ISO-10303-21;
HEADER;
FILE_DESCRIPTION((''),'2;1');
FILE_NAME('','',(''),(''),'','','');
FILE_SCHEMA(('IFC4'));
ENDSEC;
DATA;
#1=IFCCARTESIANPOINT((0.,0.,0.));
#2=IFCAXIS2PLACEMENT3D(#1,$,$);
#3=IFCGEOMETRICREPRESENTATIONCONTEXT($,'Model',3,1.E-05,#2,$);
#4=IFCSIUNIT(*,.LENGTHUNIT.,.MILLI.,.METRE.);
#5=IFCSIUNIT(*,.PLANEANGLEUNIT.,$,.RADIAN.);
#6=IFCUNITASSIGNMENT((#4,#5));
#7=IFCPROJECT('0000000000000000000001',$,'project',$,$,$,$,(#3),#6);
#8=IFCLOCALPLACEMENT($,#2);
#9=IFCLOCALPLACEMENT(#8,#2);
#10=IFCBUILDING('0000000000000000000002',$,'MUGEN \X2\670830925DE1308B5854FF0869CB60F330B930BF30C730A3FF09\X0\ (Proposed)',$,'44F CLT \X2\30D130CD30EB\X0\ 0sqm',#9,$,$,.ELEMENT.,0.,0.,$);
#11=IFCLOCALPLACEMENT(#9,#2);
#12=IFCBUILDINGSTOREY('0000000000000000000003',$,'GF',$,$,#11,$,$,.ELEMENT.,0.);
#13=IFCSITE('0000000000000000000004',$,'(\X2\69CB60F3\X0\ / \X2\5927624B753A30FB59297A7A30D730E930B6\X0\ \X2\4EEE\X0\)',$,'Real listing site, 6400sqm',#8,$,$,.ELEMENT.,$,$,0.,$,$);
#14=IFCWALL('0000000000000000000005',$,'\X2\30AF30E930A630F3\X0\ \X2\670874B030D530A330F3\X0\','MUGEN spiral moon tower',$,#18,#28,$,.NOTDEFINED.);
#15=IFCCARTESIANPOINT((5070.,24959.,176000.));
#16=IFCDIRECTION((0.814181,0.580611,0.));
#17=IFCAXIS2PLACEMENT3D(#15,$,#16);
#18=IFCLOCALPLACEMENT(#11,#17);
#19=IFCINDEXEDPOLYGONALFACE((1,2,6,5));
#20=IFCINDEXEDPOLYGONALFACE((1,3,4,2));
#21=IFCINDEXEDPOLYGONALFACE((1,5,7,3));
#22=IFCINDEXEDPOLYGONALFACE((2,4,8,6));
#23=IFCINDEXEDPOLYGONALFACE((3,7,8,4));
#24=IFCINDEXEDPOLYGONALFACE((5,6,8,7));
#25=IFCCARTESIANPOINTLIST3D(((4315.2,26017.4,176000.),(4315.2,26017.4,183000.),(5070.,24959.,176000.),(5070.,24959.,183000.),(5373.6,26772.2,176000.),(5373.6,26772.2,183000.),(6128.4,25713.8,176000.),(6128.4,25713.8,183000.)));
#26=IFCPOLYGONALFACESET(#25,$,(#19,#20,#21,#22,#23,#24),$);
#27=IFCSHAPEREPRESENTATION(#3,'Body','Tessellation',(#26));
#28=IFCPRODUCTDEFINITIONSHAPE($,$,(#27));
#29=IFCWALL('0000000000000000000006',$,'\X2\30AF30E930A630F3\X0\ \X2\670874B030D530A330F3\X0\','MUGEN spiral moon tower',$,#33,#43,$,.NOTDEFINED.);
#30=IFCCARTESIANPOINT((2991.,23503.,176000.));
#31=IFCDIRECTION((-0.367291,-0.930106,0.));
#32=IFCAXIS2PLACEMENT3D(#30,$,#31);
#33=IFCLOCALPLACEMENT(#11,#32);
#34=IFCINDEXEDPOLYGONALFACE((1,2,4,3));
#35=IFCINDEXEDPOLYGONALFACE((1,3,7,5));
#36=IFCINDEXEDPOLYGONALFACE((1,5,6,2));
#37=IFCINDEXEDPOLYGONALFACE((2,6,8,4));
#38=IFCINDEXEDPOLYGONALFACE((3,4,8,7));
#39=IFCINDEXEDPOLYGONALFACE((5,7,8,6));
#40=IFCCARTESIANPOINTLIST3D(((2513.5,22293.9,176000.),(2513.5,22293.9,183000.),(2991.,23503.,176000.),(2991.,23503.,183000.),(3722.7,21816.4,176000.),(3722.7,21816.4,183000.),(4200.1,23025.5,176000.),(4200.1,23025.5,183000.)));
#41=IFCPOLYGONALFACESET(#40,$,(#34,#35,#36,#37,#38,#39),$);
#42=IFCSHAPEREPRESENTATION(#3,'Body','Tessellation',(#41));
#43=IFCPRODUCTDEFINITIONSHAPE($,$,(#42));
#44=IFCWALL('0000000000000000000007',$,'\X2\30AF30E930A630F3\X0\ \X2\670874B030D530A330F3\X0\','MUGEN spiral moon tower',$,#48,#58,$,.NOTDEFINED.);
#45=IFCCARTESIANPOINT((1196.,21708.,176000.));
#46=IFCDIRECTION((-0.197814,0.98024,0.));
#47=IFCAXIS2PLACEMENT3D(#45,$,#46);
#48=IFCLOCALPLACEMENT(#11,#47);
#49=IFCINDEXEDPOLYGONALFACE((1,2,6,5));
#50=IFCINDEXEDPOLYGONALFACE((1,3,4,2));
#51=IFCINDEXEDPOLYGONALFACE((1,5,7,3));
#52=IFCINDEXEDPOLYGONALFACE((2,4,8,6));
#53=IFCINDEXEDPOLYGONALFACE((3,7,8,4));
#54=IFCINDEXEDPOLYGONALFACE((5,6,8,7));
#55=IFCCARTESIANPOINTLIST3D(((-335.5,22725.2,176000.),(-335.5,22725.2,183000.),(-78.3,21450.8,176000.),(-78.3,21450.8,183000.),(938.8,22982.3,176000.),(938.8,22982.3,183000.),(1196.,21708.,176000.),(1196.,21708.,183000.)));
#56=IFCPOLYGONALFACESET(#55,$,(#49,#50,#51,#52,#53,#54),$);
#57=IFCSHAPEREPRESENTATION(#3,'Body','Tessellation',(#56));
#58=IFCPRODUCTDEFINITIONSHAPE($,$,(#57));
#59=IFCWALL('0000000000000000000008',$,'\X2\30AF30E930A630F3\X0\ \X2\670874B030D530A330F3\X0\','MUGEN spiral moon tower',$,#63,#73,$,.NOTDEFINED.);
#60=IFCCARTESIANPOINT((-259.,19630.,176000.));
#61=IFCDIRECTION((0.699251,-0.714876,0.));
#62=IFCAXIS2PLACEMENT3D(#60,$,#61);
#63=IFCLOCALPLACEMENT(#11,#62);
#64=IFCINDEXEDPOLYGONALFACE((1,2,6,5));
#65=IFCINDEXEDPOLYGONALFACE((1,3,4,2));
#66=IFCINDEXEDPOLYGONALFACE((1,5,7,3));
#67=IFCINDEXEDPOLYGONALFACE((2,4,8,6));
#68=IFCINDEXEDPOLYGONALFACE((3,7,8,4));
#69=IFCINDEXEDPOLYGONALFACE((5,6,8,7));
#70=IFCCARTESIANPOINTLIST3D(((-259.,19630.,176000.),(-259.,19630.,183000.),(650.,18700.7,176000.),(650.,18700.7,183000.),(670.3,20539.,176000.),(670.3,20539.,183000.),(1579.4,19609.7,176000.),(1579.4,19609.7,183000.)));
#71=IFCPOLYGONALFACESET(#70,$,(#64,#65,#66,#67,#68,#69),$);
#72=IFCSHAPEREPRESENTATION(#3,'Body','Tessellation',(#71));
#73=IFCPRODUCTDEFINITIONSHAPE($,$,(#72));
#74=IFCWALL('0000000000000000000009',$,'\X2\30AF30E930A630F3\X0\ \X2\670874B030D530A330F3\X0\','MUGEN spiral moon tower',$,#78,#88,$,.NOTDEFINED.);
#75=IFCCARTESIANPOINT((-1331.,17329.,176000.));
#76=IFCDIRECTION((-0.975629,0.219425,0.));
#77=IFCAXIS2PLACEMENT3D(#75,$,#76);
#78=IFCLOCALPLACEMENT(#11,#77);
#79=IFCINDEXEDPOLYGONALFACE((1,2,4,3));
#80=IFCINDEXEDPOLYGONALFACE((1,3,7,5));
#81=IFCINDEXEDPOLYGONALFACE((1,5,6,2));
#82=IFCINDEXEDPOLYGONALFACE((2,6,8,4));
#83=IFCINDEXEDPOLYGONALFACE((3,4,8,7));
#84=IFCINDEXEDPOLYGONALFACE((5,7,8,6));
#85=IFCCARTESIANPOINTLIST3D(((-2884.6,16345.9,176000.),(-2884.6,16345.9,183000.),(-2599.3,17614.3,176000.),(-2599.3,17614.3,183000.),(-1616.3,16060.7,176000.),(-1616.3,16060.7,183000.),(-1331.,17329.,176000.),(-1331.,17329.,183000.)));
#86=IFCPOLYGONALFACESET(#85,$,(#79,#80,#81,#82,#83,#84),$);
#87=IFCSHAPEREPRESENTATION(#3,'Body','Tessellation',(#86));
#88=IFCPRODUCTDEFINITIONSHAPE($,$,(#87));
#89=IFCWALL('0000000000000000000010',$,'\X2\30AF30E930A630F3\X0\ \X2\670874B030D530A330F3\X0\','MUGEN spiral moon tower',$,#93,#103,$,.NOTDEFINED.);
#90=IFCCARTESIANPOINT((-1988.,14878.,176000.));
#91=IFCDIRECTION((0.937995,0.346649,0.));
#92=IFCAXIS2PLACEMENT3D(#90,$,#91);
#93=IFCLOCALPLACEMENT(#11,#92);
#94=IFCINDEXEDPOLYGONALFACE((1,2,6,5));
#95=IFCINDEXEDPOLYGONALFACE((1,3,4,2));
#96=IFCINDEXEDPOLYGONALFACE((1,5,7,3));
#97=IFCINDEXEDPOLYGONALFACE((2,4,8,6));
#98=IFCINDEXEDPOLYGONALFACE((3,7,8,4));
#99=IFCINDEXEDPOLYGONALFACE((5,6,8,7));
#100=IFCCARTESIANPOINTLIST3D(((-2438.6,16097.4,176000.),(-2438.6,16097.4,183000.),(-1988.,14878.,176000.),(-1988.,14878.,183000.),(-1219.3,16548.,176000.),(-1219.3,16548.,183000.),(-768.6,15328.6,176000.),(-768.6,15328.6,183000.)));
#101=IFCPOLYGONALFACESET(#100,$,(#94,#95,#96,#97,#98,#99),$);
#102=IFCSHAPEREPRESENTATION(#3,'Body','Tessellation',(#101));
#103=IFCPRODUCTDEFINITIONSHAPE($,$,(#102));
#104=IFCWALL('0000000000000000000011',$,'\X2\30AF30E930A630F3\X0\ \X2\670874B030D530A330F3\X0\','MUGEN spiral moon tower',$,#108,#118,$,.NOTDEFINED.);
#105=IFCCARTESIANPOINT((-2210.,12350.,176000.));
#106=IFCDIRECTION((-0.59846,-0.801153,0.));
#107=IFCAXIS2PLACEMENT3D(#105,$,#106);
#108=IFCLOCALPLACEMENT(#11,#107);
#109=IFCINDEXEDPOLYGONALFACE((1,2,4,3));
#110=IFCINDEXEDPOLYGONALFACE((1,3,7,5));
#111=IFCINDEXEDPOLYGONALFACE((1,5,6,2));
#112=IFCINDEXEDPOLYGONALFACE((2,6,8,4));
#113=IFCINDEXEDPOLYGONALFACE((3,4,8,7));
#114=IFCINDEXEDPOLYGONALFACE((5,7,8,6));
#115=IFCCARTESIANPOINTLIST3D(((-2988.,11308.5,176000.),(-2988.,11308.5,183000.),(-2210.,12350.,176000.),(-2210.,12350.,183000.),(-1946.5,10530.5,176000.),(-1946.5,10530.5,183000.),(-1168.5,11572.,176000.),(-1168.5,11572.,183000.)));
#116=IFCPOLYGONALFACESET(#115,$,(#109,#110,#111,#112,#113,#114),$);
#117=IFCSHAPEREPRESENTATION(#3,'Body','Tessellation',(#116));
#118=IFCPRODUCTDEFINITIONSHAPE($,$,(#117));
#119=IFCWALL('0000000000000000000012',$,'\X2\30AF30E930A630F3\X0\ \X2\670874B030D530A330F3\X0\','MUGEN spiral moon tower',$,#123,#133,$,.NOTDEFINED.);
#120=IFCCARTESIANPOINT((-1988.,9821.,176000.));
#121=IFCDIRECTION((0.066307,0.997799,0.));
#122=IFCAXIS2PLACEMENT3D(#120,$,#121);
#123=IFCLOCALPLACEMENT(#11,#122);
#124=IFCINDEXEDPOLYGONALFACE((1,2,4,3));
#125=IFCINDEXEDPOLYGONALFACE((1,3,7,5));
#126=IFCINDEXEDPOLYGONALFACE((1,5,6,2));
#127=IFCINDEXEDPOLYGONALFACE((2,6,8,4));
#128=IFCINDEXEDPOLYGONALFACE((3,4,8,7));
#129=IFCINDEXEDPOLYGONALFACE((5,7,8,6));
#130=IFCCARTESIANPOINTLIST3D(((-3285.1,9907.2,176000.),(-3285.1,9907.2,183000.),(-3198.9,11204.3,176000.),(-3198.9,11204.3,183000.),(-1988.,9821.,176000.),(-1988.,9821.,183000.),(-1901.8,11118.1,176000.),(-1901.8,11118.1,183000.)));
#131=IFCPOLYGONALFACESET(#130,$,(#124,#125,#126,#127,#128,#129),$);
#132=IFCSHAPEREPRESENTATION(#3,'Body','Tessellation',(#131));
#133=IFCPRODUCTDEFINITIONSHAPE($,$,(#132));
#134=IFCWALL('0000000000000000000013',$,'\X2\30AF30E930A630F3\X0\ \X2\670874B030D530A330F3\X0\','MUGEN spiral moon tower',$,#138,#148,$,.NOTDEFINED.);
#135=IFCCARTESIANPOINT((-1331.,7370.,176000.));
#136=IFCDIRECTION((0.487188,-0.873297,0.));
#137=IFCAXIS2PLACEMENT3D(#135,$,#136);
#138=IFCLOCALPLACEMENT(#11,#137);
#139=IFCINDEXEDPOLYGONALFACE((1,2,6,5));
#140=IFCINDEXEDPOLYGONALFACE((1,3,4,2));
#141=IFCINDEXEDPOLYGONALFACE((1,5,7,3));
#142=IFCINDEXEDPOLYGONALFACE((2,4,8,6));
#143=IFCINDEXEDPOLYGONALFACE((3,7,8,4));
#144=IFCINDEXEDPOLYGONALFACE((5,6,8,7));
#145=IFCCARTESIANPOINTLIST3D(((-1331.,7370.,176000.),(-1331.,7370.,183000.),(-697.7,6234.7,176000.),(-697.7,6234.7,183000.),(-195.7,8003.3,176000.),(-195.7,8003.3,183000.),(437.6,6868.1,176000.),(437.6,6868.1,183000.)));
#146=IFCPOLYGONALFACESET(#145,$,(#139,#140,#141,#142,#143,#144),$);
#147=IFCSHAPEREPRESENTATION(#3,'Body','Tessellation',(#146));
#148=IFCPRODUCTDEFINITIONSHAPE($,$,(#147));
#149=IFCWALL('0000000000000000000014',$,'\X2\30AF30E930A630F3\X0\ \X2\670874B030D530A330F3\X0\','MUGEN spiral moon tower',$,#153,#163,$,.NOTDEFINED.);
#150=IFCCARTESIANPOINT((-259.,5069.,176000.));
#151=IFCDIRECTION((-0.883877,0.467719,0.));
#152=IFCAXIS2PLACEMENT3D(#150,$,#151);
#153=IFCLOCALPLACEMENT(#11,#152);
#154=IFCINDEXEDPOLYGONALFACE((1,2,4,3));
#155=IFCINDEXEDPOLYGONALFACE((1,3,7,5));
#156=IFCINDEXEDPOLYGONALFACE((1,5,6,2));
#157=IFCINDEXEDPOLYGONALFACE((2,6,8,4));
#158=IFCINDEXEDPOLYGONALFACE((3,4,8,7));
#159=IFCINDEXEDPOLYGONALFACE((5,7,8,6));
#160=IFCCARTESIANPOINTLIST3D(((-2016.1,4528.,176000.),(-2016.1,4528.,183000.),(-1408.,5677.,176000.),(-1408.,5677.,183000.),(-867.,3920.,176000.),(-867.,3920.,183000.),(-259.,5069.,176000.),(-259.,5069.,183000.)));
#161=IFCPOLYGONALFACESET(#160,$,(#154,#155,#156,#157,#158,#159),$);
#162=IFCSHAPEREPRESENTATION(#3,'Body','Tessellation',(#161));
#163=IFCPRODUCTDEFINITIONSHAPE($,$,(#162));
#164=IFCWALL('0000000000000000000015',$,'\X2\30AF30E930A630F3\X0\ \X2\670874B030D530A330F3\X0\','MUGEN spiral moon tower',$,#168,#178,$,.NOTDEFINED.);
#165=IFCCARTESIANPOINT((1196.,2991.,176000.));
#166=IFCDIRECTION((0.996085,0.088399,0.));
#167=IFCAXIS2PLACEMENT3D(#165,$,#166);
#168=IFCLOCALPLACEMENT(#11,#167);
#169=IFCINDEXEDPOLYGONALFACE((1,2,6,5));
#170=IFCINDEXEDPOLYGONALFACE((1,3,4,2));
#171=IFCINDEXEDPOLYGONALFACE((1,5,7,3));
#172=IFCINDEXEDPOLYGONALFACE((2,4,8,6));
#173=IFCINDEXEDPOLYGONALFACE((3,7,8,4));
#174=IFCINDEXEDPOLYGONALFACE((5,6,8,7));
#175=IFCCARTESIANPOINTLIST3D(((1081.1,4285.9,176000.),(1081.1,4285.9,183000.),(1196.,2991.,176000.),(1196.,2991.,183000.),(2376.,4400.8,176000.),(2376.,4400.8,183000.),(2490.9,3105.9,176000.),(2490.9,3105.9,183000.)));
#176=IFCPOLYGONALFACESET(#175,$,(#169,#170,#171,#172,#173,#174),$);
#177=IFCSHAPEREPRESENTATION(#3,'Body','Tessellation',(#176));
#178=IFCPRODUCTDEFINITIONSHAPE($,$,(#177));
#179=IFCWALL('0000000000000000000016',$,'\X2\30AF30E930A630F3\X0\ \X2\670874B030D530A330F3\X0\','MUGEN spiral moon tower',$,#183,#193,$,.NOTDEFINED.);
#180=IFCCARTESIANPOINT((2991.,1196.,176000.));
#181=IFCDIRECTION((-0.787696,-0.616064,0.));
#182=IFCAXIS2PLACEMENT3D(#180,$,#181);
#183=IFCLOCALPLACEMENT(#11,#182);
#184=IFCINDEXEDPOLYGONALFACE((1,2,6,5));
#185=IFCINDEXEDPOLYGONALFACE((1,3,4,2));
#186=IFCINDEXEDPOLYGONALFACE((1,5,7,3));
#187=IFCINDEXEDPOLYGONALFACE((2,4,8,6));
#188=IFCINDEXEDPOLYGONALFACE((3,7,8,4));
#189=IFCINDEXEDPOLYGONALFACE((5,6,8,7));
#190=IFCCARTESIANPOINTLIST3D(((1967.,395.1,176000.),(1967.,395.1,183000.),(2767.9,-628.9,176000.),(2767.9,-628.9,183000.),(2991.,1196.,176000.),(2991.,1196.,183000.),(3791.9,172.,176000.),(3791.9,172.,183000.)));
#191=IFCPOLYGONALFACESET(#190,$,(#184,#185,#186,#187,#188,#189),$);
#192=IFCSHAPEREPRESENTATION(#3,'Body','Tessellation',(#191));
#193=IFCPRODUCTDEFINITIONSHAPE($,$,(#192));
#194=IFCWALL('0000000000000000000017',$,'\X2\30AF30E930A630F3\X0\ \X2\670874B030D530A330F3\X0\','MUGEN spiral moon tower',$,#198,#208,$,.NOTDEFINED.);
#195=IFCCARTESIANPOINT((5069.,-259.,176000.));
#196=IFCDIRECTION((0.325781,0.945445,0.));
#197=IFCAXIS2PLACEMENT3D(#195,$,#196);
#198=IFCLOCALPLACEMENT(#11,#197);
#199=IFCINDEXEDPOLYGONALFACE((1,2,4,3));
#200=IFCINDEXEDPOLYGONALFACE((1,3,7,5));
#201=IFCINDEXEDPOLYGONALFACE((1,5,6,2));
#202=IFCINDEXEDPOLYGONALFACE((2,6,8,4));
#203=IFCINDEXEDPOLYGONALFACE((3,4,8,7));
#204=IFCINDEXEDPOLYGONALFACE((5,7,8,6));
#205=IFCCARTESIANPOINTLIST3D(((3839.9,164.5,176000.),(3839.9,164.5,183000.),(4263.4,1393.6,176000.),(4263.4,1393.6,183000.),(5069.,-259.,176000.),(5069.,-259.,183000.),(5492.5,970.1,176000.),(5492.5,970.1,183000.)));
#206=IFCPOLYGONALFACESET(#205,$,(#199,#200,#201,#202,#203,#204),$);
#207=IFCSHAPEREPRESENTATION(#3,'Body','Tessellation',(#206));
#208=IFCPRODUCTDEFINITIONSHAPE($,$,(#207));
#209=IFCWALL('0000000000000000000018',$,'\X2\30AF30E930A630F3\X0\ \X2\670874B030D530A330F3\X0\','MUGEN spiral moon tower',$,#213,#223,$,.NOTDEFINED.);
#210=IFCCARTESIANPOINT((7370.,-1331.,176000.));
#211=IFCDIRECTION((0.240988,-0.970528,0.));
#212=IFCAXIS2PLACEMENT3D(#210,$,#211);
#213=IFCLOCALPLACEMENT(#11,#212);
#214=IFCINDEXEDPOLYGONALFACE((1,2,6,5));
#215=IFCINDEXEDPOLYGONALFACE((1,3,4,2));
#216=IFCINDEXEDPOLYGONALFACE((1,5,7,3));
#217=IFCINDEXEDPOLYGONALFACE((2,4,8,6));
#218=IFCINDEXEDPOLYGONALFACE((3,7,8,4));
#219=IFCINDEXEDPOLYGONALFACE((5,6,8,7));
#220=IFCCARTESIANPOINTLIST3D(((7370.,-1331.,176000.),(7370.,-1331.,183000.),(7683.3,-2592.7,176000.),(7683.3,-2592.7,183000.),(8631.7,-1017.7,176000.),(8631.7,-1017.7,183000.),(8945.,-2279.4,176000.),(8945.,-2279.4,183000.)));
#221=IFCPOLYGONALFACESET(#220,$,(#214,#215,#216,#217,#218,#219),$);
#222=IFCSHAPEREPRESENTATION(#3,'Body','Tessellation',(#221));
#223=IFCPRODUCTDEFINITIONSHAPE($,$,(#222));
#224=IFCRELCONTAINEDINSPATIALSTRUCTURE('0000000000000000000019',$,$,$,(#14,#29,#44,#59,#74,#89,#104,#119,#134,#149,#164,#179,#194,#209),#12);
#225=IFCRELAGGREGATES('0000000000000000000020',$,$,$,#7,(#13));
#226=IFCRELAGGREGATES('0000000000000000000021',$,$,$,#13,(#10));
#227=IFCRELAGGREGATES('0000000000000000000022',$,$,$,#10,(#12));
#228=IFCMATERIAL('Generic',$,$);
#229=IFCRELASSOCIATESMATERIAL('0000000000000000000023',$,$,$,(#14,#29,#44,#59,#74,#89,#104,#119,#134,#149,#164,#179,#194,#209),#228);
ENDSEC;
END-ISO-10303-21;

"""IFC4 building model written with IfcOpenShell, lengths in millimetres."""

from ifc_helpers import new_model, si_unit, frame, frame_2d, origin, place, context, project, spatial, rectangle, extrude, material, element, save


model = new_model("IFC4")

# Units and contexts
model_context = context("Model", 3, precision=1e-05, world=origin())
ifc_project = project(units=[si_unit("LENGTHUNIT", "METRE", prefix="MILLI"), si_unit("PLANEANGLEUNIT", "RADIAN")], contexts=[model_context])

# Site, building, storey
site_placement = place(None, origin())
site = spatial("IfcSite", under=ifc_project, at=site_placement, Name="(構想 / 大手町・天空プラザ 仮)", ObjectType="Real listing site, 6400sqm", CompositionType="ELEMENT", RefElevation=0.0)
building_placement = place(site_placement, origin())
building = spatial("IfcBuilding", under=site, at=building_placement, Name="MUGEN 月を巡る塔（構想スタディ） (Proposed)", ObjectType="44F CLT パネル 0sqm", CompositionType="ELEMENT", ElevationOfRefHeight=0.0, ElevationOfTerrain=0.0)
storey_placement = place(building_placement, origin())
storey = spatial("IfcBuildingStorey", under=building, at=storey_placement, Name="GF", CompositionType="ELEMENT", Elevation=0.0)

# Shared definitions
ifc_material = material(Name="Generic")

# Walls
wall_1_placement = place(storey_placement, frame((5070.0, 24959.0, 176000.0), x_axis=(0.814181, 0.580611, 0.0)))
element("IfcWall", 1, at=wall_1_placement, inside=storey, material=ifc_material, Name="クラウン 月環フィン", Description="MUGEN spiral moon tower", PredefinedType="NOTDEFINED", context=model_context, shape_type="SweptSolid", body=[
    extrude(rectangle(XDim=1300.0, YDim=1300.0, at=frame_2d((650.0, 650.0))), frame((5070.0, 24959.0, 176000.0), x_axis=(0.814181, 0.580611, 0.0)), (0.0, 0.0, 1.0), 7000.0),
])
wall_2_placement = place(storey_placement, frame((2991.0, 23503.0, 176000.0), x_axis=(-0.367291, -0.930106, 0.0)))
element("IfcWall", 2, at=wall_2_placement, inside=storey, material=ifc_material, Name="クラウン 月環フィン", Description="MUGEN spiral moon tower", PredefinedType="NOTDEFINED", context=model_context, shape_type="SweptSolid", body=[
    extrude(rectangle(XDim=1300.0, YDim=1300.0, at=frame_2d((650.0, 650.0))), frame((2991.0, 23503.0, 176000.0), x_axis=(-0.367291, -0.930106, 0.0)), (0.0, 0.0, 1.0), 7000.0),
])
wall_3_placement = place(storey_placement, frame((1196.0, 21708.0, 176000.0), x_axis=(-0.197814, 0.98024, 0.0)))
element("IfcWall", 3, at=wall_3_placement, inside=storey, material=ifc_material, Name="クラウン 月環フィン", Description="MUGEN spiral moon tower", PredefinedType="NOTDEFINED", context=model_context, shape_type="SweptSolid", body=[
    extrude(rectangle(XDim=1300.0, YDim=1300.0, at=frame_2d((650.0, 650.0))), frame((1196.0, 21708.0, 176000.0), x_axis=(-0.197814, 0.98024, 0.0)), (0.0, 0.0, 1.0), 7000.0),
])
wall_4_placement = place(storey_placement, frame((-259.0, 19630.0, 176000.0), x_axis=(0.699251, -0.714876, 0.0)))
element("IfcWall", 4, at=wall_4_placement, inside=storey, material=ifc_material, Name="クラウン 月環フィン", Description="MUGEN spiral moon tower", PredefinedType="NOTDEFINED", context=model_context, shape_type="SweptSolid", body=[
    extrude(rectangle(XDim=1300.0, YDim=1300.0, at=frame_2d((650.0, 650.0))), frame((-259.0, 19630.0, 176000.0), x_axis=(0.699251, -0.714876, 0.0)), (0.0, 0.0, 1.0), 7000.0),
])
wall_5_placement = place(storey_placement, frame((-1331.0, 17329.0, 176000.0), x_axis=(-0.975629, 0.219425, 0.0)))
element("IfcWall", 5, at=wall_5_placement, inside=storey, material=ifc_material, Name="クラウン 月環フィン", Description="MUGEN spiral moon tower", PredefinedType="NOTDEFINED", context=model_context, shape_type="SweptSolid", body=[
    extrude(rectangle(XDim=1300.0, YDim=1300.0, at=frame_2d((650.0, 650.0))), frame((-1331.0, 17329.0, 176000.0), x_axis=(-0.975629, 0.219425, 0.0)), (0.0, 0.0, 1.0), 7000.0),
])
wall_6_placement = place(storey_placement, frame((-1988.0, 14878.0, 176000.0), x_axis=(0.937995, 0.346649, 0.0)))
element("IfcWall", 6, at=wall_6_placement, inside=storey, material=ifc_material, Name="クラウン 月環フィン", Description="MUGEN spiral moon tower", PredefinedType="NOTDEFINED", context=model_context, shape_type="SweptSolid", body=[
    extrude(rectangle(XDim=1300.0, YDim=1300.0, at=frame_2d((650.0, 650.0))), frame((-1988.0, 14878.0, 176000.0), x_axis=(0.937995, 0.346649, 0.0)), (0.0, 0.0, 1.0), 7000.0),
])
wall_7_placement = place(storey_placement, frame((-2210.0, 12350.0, 176000.0), x_axis=(-0.59846, -0.801153, 0.0)))
element("IfcWall", 7, at=wall_7_placement, inside=storey, material=ifc_material, Name="クラウン 月環フィン", Description="MUGEN spiral moon tower", PredefinedType="NOTDEFINED", context=model_context, shape_type="SweptSolid", body=[
    extrude(rectangle(XDim=1300.0, YDim=1300.0, at=frame_2d((650.0, 650.0))), frame((-2210.0, 12350.0, 176000.0), x_axis=(-0.59846, -0.801153, 0.0)), (0.0, 0.0, 1.0), 7000.0),
])
wall_8_placement = place(storey_placement, frame((-1988.0, 9821.0, 176000.0), x_axis=(0.066307, 0.997799, 0.0)))
element("IfcWall", 8, at=wall_8_placement, inside=storey, material=ifc_material, Name="クラウン 月環フィン", Description="MUGEN spiral moon tower", PredefinedType="NOTDEFINED", context=model_context, shape_type="SweptSolid", body=[
    extrude(rectangle(XDim=1300.0, YDim=1300.0, at=frame_2d((650.0, 650.0))), frame((-1988.0, 9821.0, 176000.0), x_axis=(0.066307, 0.997799, 0.0)), (0.0, 0.0, 1.0), 7000.0),
])
wall_9_placement = place(storey_placement, frame((-1331.0, 7370.0, 176000.0), x_axis=(0.487188, -0.873297, 0.0)))
element("IfcWall", 9, at=wall_9_placement, inside=storey, material=ifc_material, Name="クラウン 月環フィン", Description="MUGEN spiral moon tower", PredefinedType="NOTDEFINED", context=model_context, shape_type="SweptSolid", body=[
    extrude(rectangle(XDim=1300.0, YDim=1300.0, at=frame_2d((650.0, 650.0))), frame((-1331.0, 7370.0, 176000.0), x_axis=(0.487188, -0.873297, 0.0)), (0.0, 0.0, 1.0), 7000.0),
])
wall_10_placement = place(storey_placement, frame((-259.0, 5069.0, 176000.0), x_axis=(-0.883877, 0.467719, 0.0)))
element("IfcWall", 10, at=wall_10_placement, inside=storey, material=ifc_material, Name="クラウン 月環フィン", Description="MUGEN spiral moon tower", PredefinedType="NOTDEFINED", context=model_context, shape_type="SweptSolid", body=[
    extrude(rectangle(XDim=1300.0, YDim=1300.0, at=frame_2d((650.0, 650.0))), frame((-259.0, 5069.0, 176000.0), x_axis=(-0.883877, 0.467719, 0.0)), (0.0, 0.0, 1.0), 7000.0),
])
wall_11_placement = place(storey_placement, frame((1196.0, 2991.0, 176000.0), x_axis=(0.996085, 0.088399, 0.0)))
element("IfcWall", 11, at=wall_11_placement, inside=storey, material=ifc_material, Name="クラウン 月環フィン", Description="MUGEN spiral moon tower", PredefinedType="NOTDEFINED", context=model_context, shape_type="SweptSolid", body=[
    extrude(rectangle(XDim=1300.0, YDim=1300.0, at=frame_2d((650.0, 650.0))), frame((1196.0, 2991.0, 176000.0), x_axis=(0.996085, 0.088399, 0.0)), (0.0, 0.0, 1.0), 7000.0),
])
wall_12_placement = place(storey_placement, frame((2991.0, 1196.0, 176000.0), x_axis=(-0.787696, -0.616064, 0.0)))
element("IfcWall", 12, at=wall_12_placement, inside=storey, material=ifc_material, Name="クラウン 月環フィン", Description="MUGEN spiral moon tower", PredefinedType="NOTDEFINED", context=model_context, shape_type="SweptSolid", body=[
    extrude(rectangle(XDim=1300.0, YDim=1300.0, at=frame_2d((650.0, 650.0))), frame((2991.0, 1196.0, 176000.0), x_axis=(-0.787696, -0.616064, 0.0)), (0.0, 0.0, 1.0), 7000.0),
])
wall_13_placement = place(storey_placement, frame((5069.0, -259.0, 176000.0), x_axis=(0.325781, 0.945445, 0.0)))
element("IfcWall", 13, at=wall_13_placement, inside=storey, material=ifc_material, Name="クラウン 月環フィン", Description="MUGEN spiral moon tower", PredefinedType="NOTDEFINED", context=model_context, shape_type="SweptSolid", body=[
    extrude(rectangle(XDim=1300.0, YDim=1300.0, at=frame_2d((650.0, 650.0))), frame((5069.0, -259.0, 176000.0), x_axis=(0.325781, 0.945445, 0.0)), (0.0, 0.0, 1.0), 7000.0),
])
wall_14_placement = place(storey_placement, frame((7370.0, -1331.0, 176000.0), x_axis=(0.240988, -0.970528, 0.0)))
element("IfcWall", 14, at=wall_14_placement, inside=storey, material=ifc_material, Name="クラウン 月環フィン", Description="MUGEN spiral moon tower", PredefinedType="NOTDEFINED", context=model_context, shape_type="SweptSolid", body=[
    extrude(rectangle(XDim=1300.0, YDim=1300.0, at=frame_2d((650.0, 650.0))), frame((7370.0, -1331.0, 176000.0), x_axis=(0.240988, -0.970528, 0.0)), (0.0, 0.0, 1.0), 7000.0),
])

save(model, "model.ifc")
